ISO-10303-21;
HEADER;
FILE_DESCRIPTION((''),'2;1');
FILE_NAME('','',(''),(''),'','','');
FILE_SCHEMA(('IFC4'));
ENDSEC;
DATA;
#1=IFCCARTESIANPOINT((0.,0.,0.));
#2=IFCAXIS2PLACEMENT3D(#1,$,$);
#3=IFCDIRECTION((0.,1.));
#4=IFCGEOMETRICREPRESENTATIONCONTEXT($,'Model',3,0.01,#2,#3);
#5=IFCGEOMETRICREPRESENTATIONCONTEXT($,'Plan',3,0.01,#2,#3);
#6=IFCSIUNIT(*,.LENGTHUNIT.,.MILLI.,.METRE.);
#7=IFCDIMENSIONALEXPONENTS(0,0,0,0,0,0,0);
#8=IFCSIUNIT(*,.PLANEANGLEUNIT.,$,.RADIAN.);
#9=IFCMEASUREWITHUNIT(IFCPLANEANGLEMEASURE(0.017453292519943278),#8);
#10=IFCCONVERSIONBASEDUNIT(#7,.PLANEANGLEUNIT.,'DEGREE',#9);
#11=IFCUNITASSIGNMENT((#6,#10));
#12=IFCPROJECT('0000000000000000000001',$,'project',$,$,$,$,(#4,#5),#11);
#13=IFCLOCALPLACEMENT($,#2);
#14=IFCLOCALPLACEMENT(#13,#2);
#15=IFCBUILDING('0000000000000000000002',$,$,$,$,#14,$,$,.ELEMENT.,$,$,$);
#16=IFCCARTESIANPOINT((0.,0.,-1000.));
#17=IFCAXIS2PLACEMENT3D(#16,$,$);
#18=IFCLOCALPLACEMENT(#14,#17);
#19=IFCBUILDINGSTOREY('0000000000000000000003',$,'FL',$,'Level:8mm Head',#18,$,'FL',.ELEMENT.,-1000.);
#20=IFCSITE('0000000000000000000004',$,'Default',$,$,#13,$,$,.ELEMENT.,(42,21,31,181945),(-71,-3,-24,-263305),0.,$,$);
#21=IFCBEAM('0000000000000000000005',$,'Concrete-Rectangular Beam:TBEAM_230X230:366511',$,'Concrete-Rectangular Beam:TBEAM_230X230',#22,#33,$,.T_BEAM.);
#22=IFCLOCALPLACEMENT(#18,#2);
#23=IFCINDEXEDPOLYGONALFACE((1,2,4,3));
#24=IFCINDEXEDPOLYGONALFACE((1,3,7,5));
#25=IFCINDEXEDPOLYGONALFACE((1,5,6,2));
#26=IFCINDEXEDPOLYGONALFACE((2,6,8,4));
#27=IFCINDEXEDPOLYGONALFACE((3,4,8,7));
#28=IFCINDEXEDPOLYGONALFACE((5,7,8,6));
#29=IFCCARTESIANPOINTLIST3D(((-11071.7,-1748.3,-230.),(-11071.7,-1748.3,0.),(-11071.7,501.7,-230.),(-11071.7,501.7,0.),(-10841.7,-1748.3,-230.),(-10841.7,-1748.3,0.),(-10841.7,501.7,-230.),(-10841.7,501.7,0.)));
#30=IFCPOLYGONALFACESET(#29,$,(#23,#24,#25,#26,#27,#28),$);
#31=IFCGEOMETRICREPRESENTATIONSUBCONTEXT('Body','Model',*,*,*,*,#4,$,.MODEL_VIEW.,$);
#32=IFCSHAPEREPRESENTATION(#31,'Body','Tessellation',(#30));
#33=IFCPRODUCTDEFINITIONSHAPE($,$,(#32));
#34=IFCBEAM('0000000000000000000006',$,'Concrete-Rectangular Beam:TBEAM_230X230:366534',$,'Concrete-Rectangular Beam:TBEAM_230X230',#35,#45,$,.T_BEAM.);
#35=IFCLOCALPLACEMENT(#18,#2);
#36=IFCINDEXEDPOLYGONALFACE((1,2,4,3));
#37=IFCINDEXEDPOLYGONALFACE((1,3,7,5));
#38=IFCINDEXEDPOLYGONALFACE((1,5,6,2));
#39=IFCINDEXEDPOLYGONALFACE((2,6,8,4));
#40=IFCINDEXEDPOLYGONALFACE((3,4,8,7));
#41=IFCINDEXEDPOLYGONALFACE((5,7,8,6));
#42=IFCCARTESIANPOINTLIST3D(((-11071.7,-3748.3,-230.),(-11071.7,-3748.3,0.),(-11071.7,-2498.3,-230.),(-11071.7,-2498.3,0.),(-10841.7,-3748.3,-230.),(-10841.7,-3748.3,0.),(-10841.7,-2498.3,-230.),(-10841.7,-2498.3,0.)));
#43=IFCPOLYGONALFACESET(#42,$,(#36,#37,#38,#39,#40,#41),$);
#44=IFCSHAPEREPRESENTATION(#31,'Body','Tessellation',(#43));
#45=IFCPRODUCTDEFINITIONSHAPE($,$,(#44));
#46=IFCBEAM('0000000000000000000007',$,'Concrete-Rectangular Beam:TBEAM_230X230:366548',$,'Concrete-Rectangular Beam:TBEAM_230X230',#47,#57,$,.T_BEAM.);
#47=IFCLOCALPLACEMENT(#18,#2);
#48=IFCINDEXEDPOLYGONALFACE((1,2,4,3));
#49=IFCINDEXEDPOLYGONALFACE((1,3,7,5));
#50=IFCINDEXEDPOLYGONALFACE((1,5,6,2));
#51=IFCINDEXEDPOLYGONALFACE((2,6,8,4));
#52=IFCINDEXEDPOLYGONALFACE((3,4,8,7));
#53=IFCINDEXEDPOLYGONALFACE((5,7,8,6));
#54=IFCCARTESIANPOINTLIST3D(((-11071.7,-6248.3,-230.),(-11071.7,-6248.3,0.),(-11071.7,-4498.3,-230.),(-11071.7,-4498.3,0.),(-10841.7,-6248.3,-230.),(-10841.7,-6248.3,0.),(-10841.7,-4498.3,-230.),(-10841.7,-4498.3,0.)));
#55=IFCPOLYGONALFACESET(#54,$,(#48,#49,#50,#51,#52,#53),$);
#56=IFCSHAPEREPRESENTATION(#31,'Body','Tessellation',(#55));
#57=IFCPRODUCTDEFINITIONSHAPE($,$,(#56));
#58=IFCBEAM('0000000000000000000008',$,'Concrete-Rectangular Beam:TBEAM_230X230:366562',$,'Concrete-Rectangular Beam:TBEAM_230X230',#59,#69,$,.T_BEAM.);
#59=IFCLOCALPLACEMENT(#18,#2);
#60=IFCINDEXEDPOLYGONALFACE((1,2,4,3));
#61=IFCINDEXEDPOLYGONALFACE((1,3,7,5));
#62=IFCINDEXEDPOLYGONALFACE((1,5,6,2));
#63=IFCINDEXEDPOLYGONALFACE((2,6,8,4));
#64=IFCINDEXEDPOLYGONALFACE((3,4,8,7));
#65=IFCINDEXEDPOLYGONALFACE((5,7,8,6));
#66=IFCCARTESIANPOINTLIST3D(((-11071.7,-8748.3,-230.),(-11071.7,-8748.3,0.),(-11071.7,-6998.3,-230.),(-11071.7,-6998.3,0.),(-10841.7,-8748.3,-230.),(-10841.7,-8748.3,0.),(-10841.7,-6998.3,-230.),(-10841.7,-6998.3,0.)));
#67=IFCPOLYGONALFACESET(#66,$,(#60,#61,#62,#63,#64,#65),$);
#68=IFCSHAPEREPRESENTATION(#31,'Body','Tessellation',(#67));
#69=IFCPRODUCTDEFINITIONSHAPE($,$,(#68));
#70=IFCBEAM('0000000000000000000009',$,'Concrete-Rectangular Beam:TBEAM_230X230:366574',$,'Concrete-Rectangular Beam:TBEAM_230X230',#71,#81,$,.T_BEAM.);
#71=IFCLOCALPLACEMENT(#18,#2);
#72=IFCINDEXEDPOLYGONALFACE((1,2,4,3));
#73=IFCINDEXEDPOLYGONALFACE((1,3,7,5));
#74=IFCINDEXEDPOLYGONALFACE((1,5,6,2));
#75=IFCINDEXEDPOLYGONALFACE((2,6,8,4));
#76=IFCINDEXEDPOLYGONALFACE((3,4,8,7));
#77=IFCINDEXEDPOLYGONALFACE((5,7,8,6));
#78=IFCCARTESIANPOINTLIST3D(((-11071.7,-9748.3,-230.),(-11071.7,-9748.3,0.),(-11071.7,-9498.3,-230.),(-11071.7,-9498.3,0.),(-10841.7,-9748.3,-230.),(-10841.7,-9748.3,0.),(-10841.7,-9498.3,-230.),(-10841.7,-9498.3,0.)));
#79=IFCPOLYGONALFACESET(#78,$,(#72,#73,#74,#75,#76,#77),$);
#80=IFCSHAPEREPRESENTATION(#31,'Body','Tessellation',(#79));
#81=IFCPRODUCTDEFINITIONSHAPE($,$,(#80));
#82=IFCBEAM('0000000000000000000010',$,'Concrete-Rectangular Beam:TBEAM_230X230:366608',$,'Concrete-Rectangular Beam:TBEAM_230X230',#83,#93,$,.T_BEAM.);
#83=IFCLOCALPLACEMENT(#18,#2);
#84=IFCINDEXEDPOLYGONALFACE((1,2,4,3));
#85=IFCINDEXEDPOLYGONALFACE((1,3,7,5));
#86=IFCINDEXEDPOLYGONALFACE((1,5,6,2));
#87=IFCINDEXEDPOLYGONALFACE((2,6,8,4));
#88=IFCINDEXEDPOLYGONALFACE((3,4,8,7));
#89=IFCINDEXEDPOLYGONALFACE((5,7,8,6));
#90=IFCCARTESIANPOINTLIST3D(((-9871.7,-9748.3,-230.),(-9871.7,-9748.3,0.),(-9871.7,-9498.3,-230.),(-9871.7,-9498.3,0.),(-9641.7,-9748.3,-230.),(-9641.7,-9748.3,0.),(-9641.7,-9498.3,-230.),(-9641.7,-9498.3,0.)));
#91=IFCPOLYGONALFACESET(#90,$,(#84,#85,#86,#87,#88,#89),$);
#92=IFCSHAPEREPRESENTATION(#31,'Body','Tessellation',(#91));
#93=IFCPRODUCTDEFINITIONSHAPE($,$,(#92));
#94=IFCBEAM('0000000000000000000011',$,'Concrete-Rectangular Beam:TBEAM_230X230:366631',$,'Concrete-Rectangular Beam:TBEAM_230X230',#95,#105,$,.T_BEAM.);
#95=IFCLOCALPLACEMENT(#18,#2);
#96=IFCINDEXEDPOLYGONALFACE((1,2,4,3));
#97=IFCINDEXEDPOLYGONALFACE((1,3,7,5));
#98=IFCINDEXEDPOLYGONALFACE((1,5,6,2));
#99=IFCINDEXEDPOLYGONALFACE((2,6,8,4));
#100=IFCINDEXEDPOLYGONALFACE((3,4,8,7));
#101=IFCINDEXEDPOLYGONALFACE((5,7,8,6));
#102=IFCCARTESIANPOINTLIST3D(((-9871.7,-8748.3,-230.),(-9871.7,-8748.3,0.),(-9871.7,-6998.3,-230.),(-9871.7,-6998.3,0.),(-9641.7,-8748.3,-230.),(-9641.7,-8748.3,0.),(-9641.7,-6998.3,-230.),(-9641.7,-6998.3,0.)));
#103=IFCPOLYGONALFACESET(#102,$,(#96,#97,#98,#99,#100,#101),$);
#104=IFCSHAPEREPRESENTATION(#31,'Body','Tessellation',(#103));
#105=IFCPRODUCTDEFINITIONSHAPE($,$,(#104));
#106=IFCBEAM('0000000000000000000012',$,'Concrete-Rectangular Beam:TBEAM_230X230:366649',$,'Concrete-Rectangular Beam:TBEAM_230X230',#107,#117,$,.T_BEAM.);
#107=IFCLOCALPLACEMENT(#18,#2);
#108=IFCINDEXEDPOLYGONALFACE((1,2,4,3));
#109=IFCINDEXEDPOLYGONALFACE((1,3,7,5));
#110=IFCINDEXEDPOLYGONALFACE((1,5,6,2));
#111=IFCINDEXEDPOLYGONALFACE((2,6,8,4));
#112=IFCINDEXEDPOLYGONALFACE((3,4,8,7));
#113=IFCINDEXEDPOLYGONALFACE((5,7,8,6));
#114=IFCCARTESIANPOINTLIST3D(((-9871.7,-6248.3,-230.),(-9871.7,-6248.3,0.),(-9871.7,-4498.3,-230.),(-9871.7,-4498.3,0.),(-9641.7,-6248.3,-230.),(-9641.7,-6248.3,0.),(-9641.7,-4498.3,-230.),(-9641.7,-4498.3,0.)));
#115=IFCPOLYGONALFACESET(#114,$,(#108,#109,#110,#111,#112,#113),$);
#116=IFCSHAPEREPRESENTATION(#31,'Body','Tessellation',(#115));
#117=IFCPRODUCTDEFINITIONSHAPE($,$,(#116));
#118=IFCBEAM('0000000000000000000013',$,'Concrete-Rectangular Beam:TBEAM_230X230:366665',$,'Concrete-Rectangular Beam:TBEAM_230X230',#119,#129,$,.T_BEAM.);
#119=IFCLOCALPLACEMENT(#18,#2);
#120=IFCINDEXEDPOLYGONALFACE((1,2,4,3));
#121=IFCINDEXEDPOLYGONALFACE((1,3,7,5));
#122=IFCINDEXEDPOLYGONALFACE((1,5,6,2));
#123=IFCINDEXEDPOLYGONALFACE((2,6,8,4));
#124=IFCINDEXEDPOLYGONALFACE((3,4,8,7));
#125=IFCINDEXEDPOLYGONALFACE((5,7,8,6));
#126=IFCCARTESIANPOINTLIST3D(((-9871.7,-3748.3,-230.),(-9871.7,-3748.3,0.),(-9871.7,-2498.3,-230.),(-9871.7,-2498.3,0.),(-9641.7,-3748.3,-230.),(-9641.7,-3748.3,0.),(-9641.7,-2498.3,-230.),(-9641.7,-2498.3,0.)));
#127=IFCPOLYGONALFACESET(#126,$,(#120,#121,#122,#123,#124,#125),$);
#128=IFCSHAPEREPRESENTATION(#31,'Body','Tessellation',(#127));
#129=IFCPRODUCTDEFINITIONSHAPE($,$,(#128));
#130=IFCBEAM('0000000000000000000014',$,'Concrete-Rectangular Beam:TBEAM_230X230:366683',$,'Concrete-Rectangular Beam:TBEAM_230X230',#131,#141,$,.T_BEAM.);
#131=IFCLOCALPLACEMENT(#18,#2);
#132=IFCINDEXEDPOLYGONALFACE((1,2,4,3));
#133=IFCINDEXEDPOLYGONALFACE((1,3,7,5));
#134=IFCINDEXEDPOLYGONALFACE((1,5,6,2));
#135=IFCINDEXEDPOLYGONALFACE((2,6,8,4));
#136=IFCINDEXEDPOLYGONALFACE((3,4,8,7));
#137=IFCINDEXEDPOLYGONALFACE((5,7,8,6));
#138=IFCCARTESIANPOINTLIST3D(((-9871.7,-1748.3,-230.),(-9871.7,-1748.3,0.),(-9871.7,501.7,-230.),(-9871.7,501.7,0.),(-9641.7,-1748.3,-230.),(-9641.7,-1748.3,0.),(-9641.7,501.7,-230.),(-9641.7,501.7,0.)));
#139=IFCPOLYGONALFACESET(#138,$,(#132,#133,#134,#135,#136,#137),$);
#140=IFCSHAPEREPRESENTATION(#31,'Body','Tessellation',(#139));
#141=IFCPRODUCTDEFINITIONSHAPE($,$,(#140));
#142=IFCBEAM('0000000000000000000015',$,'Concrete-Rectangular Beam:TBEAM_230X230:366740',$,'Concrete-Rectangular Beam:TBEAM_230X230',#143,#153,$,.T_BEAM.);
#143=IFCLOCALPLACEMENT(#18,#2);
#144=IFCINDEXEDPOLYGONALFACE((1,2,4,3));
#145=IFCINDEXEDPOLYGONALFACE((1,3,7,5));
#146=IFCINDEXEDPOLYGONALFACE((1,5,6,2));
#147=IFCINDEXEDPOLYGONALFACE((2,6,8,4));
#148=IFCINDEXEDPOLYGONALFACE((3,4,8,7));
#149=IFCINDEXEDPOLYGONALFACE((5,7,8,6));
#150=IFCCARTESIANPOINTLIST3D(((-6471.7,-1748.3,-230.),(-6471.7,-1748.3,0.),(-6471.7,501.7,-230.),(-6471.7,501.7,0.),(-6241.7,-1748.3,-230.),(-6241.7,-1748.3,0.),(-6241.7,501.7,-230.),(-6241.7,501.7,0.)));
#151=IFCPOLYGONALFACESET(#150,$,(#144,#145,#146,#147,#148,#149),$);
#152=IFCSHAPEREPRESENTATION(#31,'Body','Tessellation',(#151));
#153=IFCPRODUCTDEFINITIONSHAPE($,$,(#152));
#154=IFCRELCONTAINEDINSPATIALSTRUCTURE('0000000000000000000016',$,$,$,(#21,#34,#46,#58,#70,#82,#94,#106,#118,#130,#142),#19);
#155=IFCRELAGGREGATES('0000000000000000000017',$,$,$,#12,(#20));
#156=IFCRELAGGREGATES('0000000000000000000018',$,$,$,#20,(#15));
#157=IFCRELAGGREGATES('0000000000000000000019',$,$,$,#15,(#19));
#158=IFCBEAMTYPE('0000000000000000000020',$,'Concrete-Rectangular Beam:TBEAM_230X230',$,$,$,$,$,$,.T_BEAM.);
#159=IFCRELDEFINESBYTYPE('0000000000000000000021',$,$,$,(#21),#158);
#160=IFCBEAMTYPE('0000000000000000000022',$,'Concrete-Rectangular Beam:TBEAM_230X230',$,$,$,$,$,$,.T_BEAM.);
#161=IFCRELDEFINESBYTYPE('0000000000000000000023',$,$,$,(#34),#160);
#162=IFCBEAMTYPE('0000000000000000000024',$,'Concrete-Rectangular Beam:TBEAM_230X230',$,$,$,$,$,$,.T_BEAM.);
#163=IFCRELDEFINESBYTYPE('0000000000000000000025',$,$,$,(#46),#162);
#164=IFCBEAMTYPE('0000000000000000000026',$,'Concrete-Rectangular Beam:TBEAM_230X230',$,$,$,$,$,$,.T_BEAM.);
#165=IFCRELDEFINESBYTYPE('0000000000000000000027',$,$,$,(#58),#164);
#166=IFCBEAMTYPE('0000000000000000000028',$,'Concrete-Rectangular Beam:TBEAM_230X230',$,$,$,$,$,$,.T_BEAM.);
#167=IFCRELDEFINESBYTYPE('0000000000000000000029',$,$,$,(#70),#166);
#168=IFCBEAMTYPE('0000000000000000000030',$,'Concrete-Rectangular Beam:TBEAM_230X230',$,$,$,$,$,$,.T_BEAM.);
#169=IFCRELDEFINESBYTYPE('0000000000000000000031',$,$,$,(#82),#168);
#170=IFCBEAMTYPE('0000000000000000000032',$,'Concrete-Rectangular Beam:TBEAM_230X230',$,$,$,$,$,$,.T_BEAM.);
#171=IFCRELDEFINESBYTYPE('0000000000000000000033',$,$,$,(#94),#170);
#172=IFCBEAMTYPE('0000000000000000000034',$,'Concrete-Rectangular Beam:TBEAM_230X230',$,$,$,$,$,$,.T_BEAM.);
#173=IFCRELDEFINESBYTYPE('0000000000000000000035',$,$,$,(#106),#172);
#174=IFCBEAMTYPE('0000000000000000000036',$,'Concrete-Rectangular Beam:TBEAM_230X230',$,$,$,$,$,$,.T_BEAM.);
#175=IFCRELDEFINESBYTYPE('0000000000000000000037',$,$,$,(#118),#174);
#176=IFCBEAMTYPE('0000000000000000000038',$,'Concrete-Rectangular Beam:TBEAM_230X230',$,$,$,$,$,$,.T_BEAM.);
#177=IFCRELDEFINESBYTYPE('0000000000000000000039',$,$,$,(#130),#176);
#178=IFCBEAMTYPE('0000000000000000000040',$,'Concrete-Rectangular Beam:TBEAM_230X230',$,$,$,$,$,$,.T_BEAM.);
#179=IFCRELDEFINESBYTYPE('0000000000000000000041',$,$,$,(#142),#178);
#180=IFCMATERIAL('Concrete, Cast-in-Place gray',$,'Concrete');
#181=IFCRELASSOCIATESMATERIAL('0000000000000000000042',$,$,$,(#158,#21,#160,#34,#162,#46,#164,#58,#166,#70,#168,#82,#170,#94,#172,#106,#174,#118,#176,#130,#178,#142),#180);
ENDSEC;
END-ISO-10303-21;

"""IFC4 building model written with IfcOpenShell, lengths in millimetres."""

from ifc_helpers import new_model, entity, si_unit, converted_unit, direction, frame, origin, place, context, subcontext, project, spatial, indexed_curve, outline, extrude, source, transform, mapped, material, type_object, type_shapes, element, save


model = new_model("IFC4")

# Units and contexts
model_context = context("Model", 3, precision=0.01, world=origin(), true_north=direction((0.0, 1.0)))
plan_context = context("Plan", 3, precision=0.01, world=origin(), true_north=direction((0.0, 1.0)))
body_context = subcontext(model_context, "Body", "Model", "MODEL_VIEW")
ifc_project = project(units=[si_unit("LENGTHUNIT", "METRE", prefix="MILLI"), converted_unit("PLANEANGLEUNIT", "DEGREE", entity("IfcPlaneAngleMeasure", 0.017453292519943278), si_unit("PLANEANGLEUNIT", "RADIAN"), dimensions=[0, 0, 0, 0, 0, 0, 0])], contexts=[model_context, plan_context])

# Site, building, storey
site_placement = place(None, origin())
site = spatial("IfcSite", under=ifc_project, at=site_placement, Name="Default", CompositionType="ELEMENT", RefLatitude=(42, 21, 31, 181945), RefLongitude=(-71, -3, -24, -263305), RefElevation=0.0)
building_placement = place(site_placement, origin())
building = spatial("IfcBuilding", under=site, at=building_placement, CompositionType="ELEMENT")
storey_placement = place(building_placement, frame((0.0, 0.0, -1000.0)))
storey = spatial("IfcBuildingStorey", under=building, at=storey_placement, Name="FL", ObjectType="Level:8mm Head", LongName="FL", CompositionType="ELEMENT", Elevation=-1000.0)

# Shared definitions
ifc_material = material(Name="Concrete, Cast-in-Place gray", Category="Concrete")

# Beams
beam_type_1 = type_object("IfcBeamType", Name="Concrete-Rectangular Beam:TBEAM_230X230", PredefinedType="T_BEAM", material=ifc_material)
shared_shape_1 = source(origin(), body_context, "Body", "SweptSolid", [
    extrude(outline(indexed_curve([(-115.0, -115.0), (115.0, -115.0), (115.0, 115.0), (-115.0, 115.0), (-115.0, -115.0)], self_intersect=False)), frame((-10956.7, 501.7, -1115.0), z_axis=(0.0, -1.0, 0.0), x_axis=(-1.0, 0.0, 0.0)), (0.0, 0.0, 1.0), 2250.0),
])
type_shapes(beam_type_1, [shared_shape_1])
beam_1_placement = place(storey_placement, frame((0.0, 0.0, 1000.0)))
element("IfcBeam", 1, at=beam_1_placement, inside=storey, type_object=beam_type_1, material=ifc_material, Name="Concrete-Rectangular Beam:TBEAM_230X230:366511", ObjectType="Concrete-Rectangular Beam:TBEAM_230X230", PredefinedType="T_BEAM", context=body_context, shape_type="MappedRepresentation", body=[
    mapped(shared_shape_1, transform((0.0, 0.0, 0.0), scale=1.0)),
])
beam_type_2 = type_object("IfcBeamType", Name="Concrete-Rectangular Beam:TBEAM_230X230", PredefinedType="T_BEAM", material=ifc_material)
shared_shape_2 = source(origin(), body_context, "Body", "SweptSolid", [
    extrude(outline(indexed_curve([(-115.0, -115.0), (115.0, -115.0), (115.0, 115.0), (-115.0, 115.0), (-115.0, -115.0)], self_intersect=False)), frame((-10956.7, -2498.3, -1115.0), z_axis=(0.0, -1.0, 0.0), x_axis=(-1.0, 0.0, 0.0)), (0.0, 0.0, 1.0), 1250.0),
])
type_shapes(beam_type_2, [shared_shape_2])
beam_2_placement = place(storey_placement, frame((0.0, 0.0, 1000.0)))
element("IfcBeam", 2, at=beam_2_placement, inside=storey, type_object=beam_type_2, material=ifc_material, Name="Concrete-Rectangular Beam:TBEAM_230X230:366534", ObjectType="Concrete-Rectangular Beam:TBEAM_230X230", PredefinedType="T_BEAM", context=body_context, shape_type="MappedRepresentation", body=[
    mapped(shared_shape_2, transform((0.0, 0.0, 0.0), scale=1.0)),
])
beam_type_3 = type_object("IfcBeamType", Name="Concrete-Rectangular Beam:TBEAM_230X230", PredefinedType="T_BEAM", material=ifc_material)
shared_shape_3 = source(origin(), body_context, "Body", "SweptSolid", [
    extrude(outline(indexed_curve([(-115.0, -115.0), (115.0, -115.0), (115.0, 115.0), (-115.0, 115.0), (-115.0, -115.0)], self_intersect=False)), frame((-10956.7, -4498.3, -1115.0), z_axis=(0.0, -1.0, 0.0), x_axis=(-1.0, 0.0, 0.0)), (0.0, 0.0, 1.0), 1750.0),
])
type_shapes(beam_type_3, [shared_shape_3])
beam_3_placement = place(storey_placement, frame((0.0, 0.0, 1000.0)))
element("IfcBeam", 3, at=beam_3_placement, inside=storey, type_object=beam_type_3, material=ifc_material, Name="Concrete-Rectangular Beam:TBEAM_230X230:366548", ObjectType="Concrete-Rectangular Beam:TBEAM_230X230", PredefinedType="T_BEAM", context=body_context, shape_type="MappedRepresentation", body=[
    mapped(shared_shape_3, transform((0.0, 0.0, 0.0), scale=1.0)),
])
beam_type_4 = type_object("IfcBeamType", Name="Concrete-Rectangular Beam:TBEAM_230X230", PredefinedType="T_BEAM", material=ifc_material)
shared_shape_4 = source(origin(), body_context, "Body", "SweptSolid", [
    extrude(outline(indexed_curve([(-115.0, -115.0), (115.0, -115.0), (115.0, 115.0), (-115.0, 115.0), (-115.0, -115.0)], self_intersect=False)), frame((-10956.7, -6998.3, -1115.0), z_axis=(0.0, -1.0, 0.0), x_axis=(-1.0, 0.0, 0.0)), (0.0, 0.0, 1.0), 1750.0),
])
type_shapes(beam_type_4, [shared_shape_4])
beam_4_placement = place(storey_placement, frame((0.0, 0.0, 1000.0)))
element("IfcBeam", 4, at=beam_4_placement, inside=storey, type_object=beam_type_4, material=ifc_material, Name="Concrete-Rectangular Beam:TBEAM_230X230:366562", ObjectType="Concrete-Rectangular Beam:TBEAM_230X230", PredefinedType="T_BEAM", context=body_context, shape_type="MappedRepresentation", body=[
    mapped(shared_shape_4, transform((0.0, 0.0, 0.0), scale=1.0)),
])
beam_type_5 = type_object("IfcBeamType", Name="Concrete-Rectangular Beam:TBEAM_230X230", PredefinedType="T_BEAM", material=ifc_material)
shared_shape_5 = source(origin(), body_context, "Body", "SweptSolid", [
    extrude(outline(indexed_curve([(-115.0, -115.0), (115.0, -115.0), (115.0, 115.0), (-115.0, 115.0), (-115.0, -115.0)], self_intersect=False)), frame((-10956.7, -9498.3, -1115.0), z_axis=(0.0, -1.0, 0.0), x_axis=(-1.0, 0.0, 0.0)), (0.0, 0.0, 1.0), 250.0),
])
type_shapes(beam_type_5, [shared_shape_5])
beam_5_placement = place(storey_placement, frame((0.0, 0.0, 1000.0)))
element("IfcBeam", 5, at=beam_5_placement, inside=storey, type_object=beam_type_5, material=ifc_material, Name="Concrete-Rectangular Beam:TBEAM_230X230:366574", ObjectType="Concrete-Rectangular Beam:TBEAM_230X230", PredefinedType="T_BEAM", context=body_context, shape_type="MappedRepresentation", body=[
    mapped(shared_shape_5, transform((0.0, 0.0, 0.0), scale=1.0)),
])
beam_type_6 = type_object("IfcBeamType", Name="Concrete-Rectangular Beam:TBEAM_230X230", PredefinedType="T_BEAM", material=ifc_material)
shared_shape_6 = source(origin(), body_context, "Body", "SweptSolid", [
    extrude(outline(indexed_curve([(-115.0, -115.0), (115.0, -115.0), (115.0, 115.0), (-115.0, 115.0), (-115.0, -115.0)], self_intersect=False)), frame((-9756.7, -9748.3, -1115.0), z_axis=(0.0, 1.0, 0.0), x_axis=(-1.0, 0.0, 0.0)), (0.0, 0.0, 1.0), 250.0),
])
type_shapes(beam_type_6, [shared_shape_6])
beam_6_placement = place(storey_placement, frame((0.0, 0.0, 1000.0)))
element("IfcBeam", 6, at=beam_6_placement, inside=storey, type_object=beam_type_6, material=ifc_material, Name="Concrete-Rectangular Beam:TBEAM_230X230:366608", ObjectType="Concrete-Rectangular Beam:TBEAM_230X230", PredefinedType="T_BEAM", context=body_context, shape_type="MappedRepresentation", body=[
    mapped(shared_shape_6, transform((0.0, 0.0, 0.0), scale=1.0)),
])
beam_type_7 = type_object("IfcBeamType", Name="Concrete-Rectangular Beam:TBEAM_230X230", PredefinedType="T_BEAM", material=ifc_material)
shared_shape_7 = source(origin(), body_context, "Body", "SweptSolid", [
    extrude(outline(indexed_curve([(-115.0, -115.0), (115.0, -115.0), (115.0, 115.0), (-115.0, 115.0), (-115.0, -115.0)], self_intersect=False)), frame((-9756.7, -8748.3, -1115.0), z_axis=(0.0, 1.0, 0.0), x_axis=(-1.0, 0.0, 0.0)), (0.0, 0.0, 1.0), 1750.0),
])
type_shapes(beam_type_7, [shared_shape_7])
beam_7_placement = place(storey_placement, frame((0.0, 0.0, 1000.0)))
element("IfcBeam", 7, at=beam_7_placement, inside=storey, type_object=beam_type_7, material=ifc_material, Name="Concrete-Rectangular Beam:TBEAM_230X230:366631", ObjectType="Concrete-Rectangular Beam:TBEAM_230X230", PredefinedType="T_BEAM", context=body_context, shape_type="MappedRepresentation", body=[
    mapped(shared_shape_7, transform((0.0, 0.0, 0.0), scale=1.0)),
])
beam_type_8 = type_object("IfcBeamType", Name="Concrete-Rectangular Beam:TBEAM_230X230", PredefinedType="T_BEAM", material=ifc_material)
shared_shape_8 = source(origin(), body_context, "Body", "SweptSolid", [
    extrude(outline(indexed_curve([(-115.0, -115.0), (115.0, -115.0), (115.0, 115.0), (-115.0, 115.0), (-115.0, -115.0)], self_intersect=False)), frame((-9756.7, -6248.3, -1115.0), z_axis=(0.0, 1.0, 0.0), x_axis=(-1.0, 0.0, 0.0)), (0.0, 0.0, 1.0), 1750.0),
])
type_shapes(beam_type_8, [shared_shape_8])
beam_8_placement = place(storey_placement, frame((0.0, 0.0, 1000.0)))
element("IfcBeam", 8, at=beam_8_placement, inside=storey, type_object=beam_type_8, material=ifc_material, Name="Concrete-Rectangular Beam:TBEAM_230X230:366649", ObjectType="Concrete-Rectangular Beam:TBEAM_230X230", PredefinedType="T_BEAM", context=body_context, shape_type="MappedRepresentation", body=[
    mapped(shared_shape_8, transform((0.0, 0.0, 0.0), scale=1.0)),
])
beam_type_9 = type_object("IfcBeamType", Name="Concrete-Rectangular Beam:TBEAM_230X230", PredefinedType="T_BEAM", material=ifc_material)
shared_shape_9 = source(origin(), body_context, "Body", "SweptSolid", [
    extrude(outline(indexed_curve([(-115.0, -115.0), (115.0, -115.0), (115.0, 115.0), (-115.0, 115.0), (-115.0, -115.0)], self_intersect=False)), frame((-9756.7, -3748.3, -1115.0), z_axis=(0.0, 1.0, 0.0), x_axis=(-1.0, 0.0, 0.0)), (0.0, 0.0, 1.0), 1250.0),
])
type_shapes(beam_type_9, [shared_shape_9])
beam_9_placement = place(storey_placement, frame((0.0, 0.0, 1000.0)))
element("IfcBeam", 9, at=beam_9_placement, inside=storey, type_object=beam_type_9, material=ifc_material, Name="Concrete-Rectangular Beam:TBEAM_230X230:366665", ObjectType="Concrete-Rectangular Beam:TBEAM_230X230", PredefinedType="T_BEAM", context=body_context, shape_type="MappedRepresentation", body=[
    mapped(shared_shape_9, transform((0.0, 0.0, 0.0), scale=1.0)),
])
beam_type_10 = type_object("IfcBeamType", Name="Concrete-Rectangular Beam:TBEAM_230X230", PredefinedType="T_BEAM", material=ifc_material)
shared_shape_10 = source(origin(), body_context, "Body", "SweptSolid", [
    extrude(outline(indexed_curve([(-115.0, -115.0), (115.0, -115.0), (115.0, 115.0), (-115.0, 115.0), (-115.0, -115.0)], self_intersect=False)), frame((-9756.7, -1748.3, -1115.0), z_axis=(0.0, 1.0, 0.0), x_axis=(-1.0, 0.0, 0.0)), (0.0, 0.0, 1.0), 2250.0),
])
type_shapes(beam_type_10, [shared_shape_10])
beam_10_placement = place(storey_placement, frame((0.0, 0.0, 1000.0)))
element("IfcBeam", 10, at=beam_10_placement, inside=storey, type_object=beam_type_10, material=ifc_material, Name="Concrete-Rectangular Beam:TBEAM_230X230:366683", ObjectType="Concrete-Rectangular Beam:TBEAM_230X230", PredefinedType="T_BEAM", context=body_context, shape_type="MappedRepresentation", body=[
    mapped(shared_shape_10, transform((0.0, 0.0, 0.0), scale=1.0)),
])
beam_type_11 = type_object("IfcBeamType", Name="Concrete-Rectangular Beam:TBEAM_230X230", PredefinedType="T_BEAM", material=ifc_material)
shared_shape_11 = source(origin(), body_context, "Body", "SweptSolid", [
    extrude(outline(indexed_curve([(-115.0, -115.0), (115.0, -115.0), (115.0, 115.0), (-115.0, 115.0), (-115.0, -115.0)], self_intersect=False)), frame((-6356.7, 501.7, -1115.0), z_axis=(0.0, -1.0, 0.0), x_axis=(-1.0, 0.0, 0.0)), (0.0, 0.0, 1.0), 2250.0),
])
type_shapes(beam_type_11, [shared_shape_11])
beam_11_placement = place(storey_placement, frame((0.0, 0.0, 1000.0)))
element("IfcBeam", 11, at=beam_11_placement, inside=storey, type_object=beam_type_11, material=ifc_material, Name="Concrete-Rectangular Beam:TBEAM_230X230:366740", ObjectType="Concrete-Rectangular Beam:TBEAM_230X230", PredefinedType="T_BEAM", context=body_context, shape_type="MappedRepresentation", body=[
    mapped(shared_shape_11, transform((0.0, 0.0, 0.0), scale=1.0)),
])

save(model, "model.ifc")
